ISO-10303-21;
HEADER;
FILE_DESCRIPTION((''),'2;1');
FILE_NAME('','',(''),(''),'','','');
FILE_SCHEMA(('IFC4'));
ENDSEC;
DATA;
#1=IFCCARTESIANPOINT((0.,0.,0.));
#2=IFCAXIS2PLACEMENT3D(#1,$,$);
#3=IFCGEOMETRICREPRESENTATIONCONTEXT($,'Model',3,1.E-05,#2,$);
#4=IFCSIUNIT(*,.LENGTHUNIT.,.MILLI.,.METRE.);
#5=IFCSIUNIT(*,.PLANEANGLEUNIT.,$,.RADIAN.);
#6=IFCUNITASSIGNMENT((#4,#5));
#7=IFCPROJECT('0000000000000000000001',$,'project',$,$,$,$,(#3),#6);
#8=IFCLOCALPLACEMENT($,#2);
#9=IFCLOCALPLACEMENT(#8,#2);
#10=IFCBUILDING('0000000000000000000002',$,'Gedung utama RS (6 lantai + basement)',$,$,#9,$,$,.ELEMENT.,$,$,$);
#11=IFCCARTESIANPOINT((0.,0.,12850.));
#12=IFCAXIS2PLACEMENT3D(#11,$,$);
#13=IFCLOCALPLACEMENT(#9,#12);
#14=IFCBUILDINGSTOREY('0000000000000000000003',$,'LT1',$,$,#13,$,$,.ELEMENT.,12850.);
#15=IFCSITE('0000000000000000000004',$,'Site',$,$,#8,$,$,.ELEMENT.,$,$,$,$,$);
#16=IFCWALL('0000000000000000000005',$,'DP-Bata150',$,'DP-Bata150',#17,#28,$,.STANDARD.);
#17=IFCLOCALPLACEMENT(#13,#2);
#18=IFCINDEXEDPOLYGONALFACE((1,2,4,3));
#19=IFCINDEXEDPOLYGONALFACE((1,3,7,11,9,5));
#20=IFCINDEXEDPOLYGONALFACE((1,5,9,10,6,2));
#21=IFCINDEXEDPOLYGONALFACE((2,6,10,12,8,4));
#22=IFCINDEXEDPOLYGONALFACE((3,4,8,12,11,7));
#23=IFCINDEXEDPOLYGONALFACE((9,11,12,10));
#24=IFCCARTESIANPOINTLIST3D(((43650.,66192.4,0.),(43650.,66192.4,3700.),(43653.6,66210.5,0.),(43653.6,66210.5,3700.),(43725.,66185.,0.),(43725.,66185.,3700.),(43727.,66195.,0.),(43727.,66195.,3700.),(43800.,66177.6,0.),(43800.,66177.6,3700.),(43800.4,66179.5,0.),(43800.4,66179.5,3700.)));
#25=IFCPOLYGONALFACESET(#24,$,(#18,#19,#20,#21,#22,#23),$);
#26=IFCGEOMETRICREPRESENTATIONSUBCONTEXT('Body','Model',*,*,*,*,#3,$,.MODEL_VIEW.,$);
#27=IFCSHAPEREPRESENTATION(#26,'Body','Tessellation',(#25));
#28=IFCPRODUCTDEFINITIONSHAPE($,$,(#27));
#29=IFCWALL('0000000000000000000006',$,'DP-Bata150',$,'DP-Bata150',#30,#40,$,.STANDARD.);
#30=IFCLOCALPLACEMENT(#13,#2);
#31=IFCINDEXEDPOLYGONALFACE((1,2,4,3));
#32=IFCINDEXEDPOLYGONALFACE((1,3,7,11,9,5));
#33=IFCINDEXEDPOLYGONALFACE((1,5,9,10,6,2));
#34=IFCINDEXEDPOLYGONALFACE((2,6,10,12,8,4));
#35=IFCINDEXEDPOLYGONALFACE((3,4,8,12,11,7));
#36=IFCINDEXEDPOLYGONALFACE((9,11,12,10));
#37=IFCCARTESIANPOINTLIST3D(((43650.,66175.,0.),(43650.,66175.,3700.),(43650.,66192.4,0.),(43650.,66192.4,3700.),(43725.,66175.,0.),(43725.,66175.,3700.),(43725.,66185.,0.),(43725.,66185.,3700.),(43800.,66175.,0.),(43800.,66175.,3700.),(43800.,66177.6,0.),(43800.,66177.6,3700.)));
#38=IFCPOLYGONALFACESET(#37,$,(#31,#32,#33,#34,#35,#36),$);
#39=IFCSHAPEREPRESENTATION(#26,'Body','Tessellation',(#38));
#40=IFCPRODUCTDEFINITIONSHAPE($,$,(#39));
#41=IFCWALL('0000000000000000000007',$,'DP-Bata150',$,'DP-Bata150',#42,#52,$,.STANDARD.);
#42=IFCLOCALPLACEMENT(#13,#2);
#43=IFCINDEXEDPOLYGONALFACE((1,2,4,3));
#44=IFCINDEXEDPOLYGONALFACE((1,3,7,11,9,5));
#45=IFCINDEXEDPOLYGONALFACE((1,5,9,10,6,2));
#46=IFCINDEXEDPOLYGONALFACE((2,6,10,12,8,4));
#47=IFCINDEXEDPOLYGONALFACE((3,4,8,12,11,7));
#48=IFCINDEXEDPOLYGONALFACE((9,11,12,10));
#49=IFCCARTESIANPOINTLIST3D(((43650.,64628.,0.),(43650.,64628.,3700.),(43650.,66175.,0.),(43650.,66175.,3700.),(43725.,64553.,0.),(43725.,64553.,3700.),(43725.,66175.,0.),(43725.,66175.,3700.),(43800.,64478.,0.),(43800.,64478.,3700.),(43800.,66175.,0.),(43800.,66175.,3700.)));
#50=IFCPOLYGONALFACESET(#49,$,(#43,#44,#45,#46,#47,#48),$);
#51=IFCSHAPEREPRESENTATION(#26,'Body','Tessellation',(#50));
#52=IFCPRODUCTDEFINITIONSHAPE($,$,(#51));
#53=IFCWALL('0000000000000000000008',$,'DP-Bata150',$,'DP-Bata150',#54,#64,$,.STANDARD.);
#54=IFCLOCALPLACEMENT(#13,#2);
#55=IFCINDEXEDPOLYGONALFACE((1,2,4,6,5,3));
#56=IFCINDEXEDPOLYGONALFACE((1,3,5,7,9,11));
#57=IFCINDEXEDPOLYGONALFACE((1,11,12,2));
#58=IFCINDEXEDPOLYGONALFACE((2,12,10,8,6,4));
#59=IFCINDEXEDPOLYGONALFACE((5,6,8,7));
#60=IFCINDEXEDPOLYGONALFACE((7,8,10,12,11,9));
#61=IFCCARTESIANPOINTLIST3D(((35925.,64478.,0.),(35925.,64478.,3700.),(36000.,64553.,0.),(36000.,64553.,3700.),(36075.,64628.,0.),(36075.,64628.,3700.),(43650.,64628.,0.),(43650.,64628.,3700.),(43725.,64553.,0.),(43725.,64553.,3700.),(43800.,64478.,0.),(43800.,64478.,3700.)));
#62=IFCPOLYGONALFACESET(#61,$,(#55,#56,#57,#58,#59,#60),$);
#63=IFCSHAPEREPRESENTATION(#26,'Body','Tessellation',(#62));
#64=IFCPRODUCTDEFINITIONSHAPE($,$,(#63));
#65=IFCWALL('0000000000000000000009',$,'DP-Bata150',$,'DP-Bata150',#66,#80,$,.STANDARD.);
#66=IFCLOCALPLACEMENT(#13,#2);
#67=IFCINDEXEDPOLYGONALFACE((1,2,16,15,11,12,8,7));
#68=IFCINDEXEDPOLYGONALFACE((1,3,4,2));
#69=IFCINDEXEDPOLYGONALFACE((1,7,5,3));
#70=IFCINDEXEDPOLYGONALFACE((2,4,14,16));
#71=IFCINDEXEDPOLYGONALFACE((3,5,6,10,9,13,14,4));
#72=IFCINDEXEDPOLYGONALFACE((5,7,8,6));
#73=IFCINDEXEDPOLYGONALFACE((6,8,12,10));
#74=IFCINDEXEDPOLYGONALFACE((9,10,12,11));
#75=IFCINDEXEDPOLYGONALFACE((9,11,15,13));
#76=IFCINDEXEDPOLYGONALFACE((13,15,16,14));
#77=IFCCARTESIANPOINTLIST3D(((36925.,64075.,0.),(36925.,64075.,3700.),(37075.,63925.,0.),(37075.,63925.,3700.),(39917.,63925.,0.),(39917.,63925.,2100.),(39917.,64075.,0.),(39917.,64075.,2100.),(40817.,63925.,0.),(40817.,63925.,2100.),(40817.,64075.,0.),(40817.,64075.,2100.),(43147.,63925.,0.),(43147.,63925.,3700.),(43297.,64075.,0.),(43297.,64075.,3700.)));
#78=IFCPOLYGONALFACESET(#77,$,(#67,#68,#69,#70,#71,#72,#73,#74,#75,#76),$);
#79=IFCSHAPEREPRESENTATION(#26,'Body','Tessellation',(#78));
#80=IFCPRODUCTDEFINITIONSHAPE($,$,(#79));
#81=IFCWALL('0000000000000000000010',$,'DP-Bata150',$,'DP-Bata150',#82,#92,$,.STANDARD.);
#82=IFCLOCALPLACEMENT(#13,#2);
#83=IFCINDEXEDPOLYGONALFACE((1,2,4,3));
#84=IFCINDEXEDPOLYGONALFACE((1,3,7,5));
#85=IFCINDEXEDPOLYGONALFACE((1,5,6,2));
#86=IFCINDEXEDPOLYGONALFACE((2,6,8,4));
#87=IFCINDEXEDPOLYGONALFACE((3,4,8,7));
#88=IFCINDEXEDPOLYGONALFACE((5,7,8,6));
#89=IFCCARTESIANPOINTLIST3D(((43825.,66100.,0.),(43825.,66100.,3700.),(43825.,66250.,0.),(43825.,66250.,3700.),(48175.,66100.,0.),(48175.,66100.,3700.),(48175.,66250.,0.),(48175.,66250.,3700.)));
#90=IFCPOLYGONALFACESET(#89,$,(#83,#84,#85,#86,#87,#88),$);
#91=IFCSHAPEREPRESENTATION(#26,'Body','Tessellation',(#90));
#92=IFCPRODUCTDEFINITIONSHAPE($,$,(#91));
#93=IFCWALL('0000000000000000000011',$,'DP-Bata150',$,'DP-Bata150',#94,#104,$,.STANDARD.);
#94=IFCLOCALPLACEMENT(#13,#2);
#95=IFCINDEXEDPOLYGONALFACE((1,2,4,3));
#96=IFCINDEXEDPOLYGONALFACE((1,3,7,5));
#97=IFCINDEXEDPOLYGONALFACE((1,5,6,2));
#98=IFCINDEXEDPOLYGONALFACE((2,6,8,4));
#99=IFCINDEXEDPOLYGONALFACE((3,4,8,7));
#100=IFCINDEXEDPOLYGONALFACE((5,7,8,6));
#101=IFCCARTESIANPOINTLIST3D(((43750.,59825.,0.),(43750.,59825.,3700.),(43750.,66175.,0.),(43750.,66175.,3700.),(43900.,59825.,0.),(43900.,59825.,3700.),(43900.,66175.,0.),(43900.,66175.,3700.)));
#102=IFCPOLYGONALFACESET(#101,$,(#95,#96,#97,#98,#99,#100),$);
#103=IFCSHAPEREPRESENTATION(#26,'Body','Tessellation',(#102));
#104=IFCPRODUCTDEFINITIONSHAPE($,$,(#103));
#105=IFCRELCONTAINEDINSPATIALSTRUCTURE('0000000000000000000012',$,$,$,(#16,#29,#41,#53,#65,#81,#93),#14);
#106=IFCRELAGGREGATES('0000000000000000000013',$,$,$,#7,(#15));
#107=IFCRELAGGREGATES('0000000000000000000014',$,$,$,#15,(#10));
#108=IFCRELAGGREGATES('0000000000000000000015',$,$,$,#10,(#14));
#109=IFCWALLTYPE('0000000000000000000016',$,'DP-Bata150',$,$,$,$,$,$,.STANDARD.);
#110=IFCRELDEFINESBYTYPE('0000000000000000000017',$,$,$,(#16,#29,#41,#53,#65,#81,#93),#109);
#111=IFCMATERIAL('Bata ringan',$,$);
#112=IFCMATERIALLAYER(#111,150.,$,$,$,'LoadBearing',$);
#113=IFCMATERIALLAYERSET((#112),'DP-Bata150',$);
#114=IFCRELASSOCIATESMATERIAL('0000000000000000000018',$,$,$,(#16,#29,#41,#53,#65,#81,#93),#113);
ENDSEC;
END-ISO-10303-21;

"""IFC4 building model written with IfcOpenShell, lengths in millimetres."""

from ifc_helpers import new_model, si_unit, frame, frame_2d, origin, place, context, subcontext, project, spatial, polyline, rectangle, outline, extrude, material, layer, layer_set, layer_usage, type_object, element, save


model = new_model("IFC4")

# Units and contexts
model_context = context("Model", 3, precision=1e-05, world=origin())
body_context = subcontext(model_context, "Body", "Model", "MODEL_VIEW")
ifc_project = project(units=[si_unit("LENGTHUNIT", "METRE", prefix="MILLI"), si_unit("PLANEANGLEUNIT", "RADIAN")], contexts=[model_context])

# Site, building, storey
site_placement = place(None, origin())
site = spatial("IfcSite", under=ifc_project, at=site_placement, Name="Site", CompositionType="ELEMENT")
building_placement = place(site_placement, origin())
building = spatial("IfcBuilding", under=site, at=building_placement, Name="Gedung utama RS (6 lantai + basement)", CompositionType="ELEMENT")
storey_placement = place(building_placement, frame((0.0, 0.0, 12850.0)))
storey = spatial("IfcBuildingStorey", under=building, at=storey_placement, Name="LT1", CompositionType="ELEMENT", Elevation=12850.0)

# Walls
ifc_material_1 = material(Name="Bata ringan")
ifc_layer_1 = layer(ifc_material_1, 150.0, Category="LoadBearing")
ifc_layer_set_1 = layer_set([ifc_layer_1], Name="DP-Bata150")
ifc_layer_usage_1 = layer_usage(ifc_layer_set_1, "AXIS2", "NEGATIVE", 75.0)
wall_type_1 = type_object("IfcWallType", Name="DP-Bata150", PredefinedType="STANDARD")
wall_1_placement = place(storey_placement, frame((43727.0, 66195.0, 0.0), z_axis=(0.0, 0.0, 1.0), x_axis=(-0.196116, -0.980581, 0.0)))
element("IfcWall", 1, at=wall_1_placement, inside=storey, type_object=wall_type_1, material=ifc_layer_usage_1, Name="DP-Bata150", ObjectType="DP-Bata150", PredefinedType="STANDARD", context=body_context, shape_type="SweptSolid", body=[
    extrude(outline(polyline([(-0.8, -75.0), (0.0, 0.0), (0.8, 75.0), (2.8, 75.0), (10.2, 0.0), (17.6, -75.0), (-0.8, -75.0)])), origin(), (0.0, 0.0, 1.0), 3700.0),
])
wall_2_placement = place(storey_placement, frame((43725.0, 66185.0, 0.0), z_axis=(0.0, 0.0, 1.0), x_axis=(0.0, -1.0, 0.0)))
element("IfcWall", 2, at=wall_2_placement, inside=storey, type_object=wall_type_1, material=ifc_layer_usage_1, Name="DP-Bata150", ObjectType="DP-Bata150", PredefinedType="STANDARD", context=body_context, shape_type="SweptSolid", body=[
    extrude(outline(polyline([(-7.4, -75.0), (0.0, 0.0), (7.4, 75.0), (10.0, 75.0), (10.0, 0.0), (10.0, -75.0), (-7.4, -75.0)])), origin(), (0.0, 0.0, 1.0), 3700.0),
])
wall_3_placement = place(storey_placement, frame((43725.0, 66175.0, 0.0), z_axis=(0.0, 0.0, 1.0), x_axis=(0.0, -1.0, 0.0)))
element("IfcWall", 3, at=wall_3_placement, inside=storey, type_object=wall_type_1, material=ifc_layer_usage_1, Name="DP-Bata150", ObjectType="DP-Bata150", PredefinedType="STANDARD", context=body_context, shape_type="SweptSolid", body=[
    extrude(outline(polyline([(0.0, -75.0), (0.0, 0.0), (0.0, 75.0), (1697.0, 75.0), (1622.0, 0.0), (1547.0, -75.0), (0.0, -75.0)])), origin(), (0.0, 0.0, 1.0), 3700.0),
])
wall_4_placement = place(storey_placement, frame((43725.0, 64553.0, 0.0), z_axis=(0.0, 0.0, 1.0), x_axis=(-1.0, 0.0, 0.0)))
element("IfcWall", 4, at=wall_4_placement, inside=storey, type_object=wall_type_1, material=ifc_layer_usage_1, Name="DP-Bata150", ObjectType="DP-Bata150", PredefinedType="STANDARD", context=body_context, shape_type="SweptSolid", body=[
    extrude(outline(polyline([(75.0, -75.0), (0.0, 0.0), (-75.0, 75.0), (7800.0, 75.0), (7725.0, 0.0), (7650.0, -75.0), (75.0, -75.0)])), origin(), (0.0, 0.0, 1.0), 3700.0),
])

# Wall, opening
wall_5_placement = place(storey_placement, frame((43222.0, 64000.0, 0.0), z_axis=(0.0, 0.0, 1.0), x_axis=(-1.0, 0.0, 0.0)))
wall_5 = element("IfcWall", 5, at=wall_5_placement, inside=storey, type_object=wall_type_1, material=ifc_layer_usage_1, Name="DP-Bata150", ObjectType="DP-Bata150", PredefinedType="STANDARD", context=body_context, shape_type="SweptSolid", body=[
    extrude(outline(polyline([(-75.0, -75.0), (0.0, 0.0), (75.0, 75.0), (6147.0, 75.0), (6222.0, 0.0), (6297.0, -75.0), (-75.0, -75.0)])), origin(), (0.0, 0.0, 1.0), 3700.0),
])
opening_placement = place(wall_5_placement, frame((2405.0, 0.0, 0.0), z_axis=(0.0, 0.0, 1.0), x_axis=(1.0, 0.0, 0.0)))
element("IfcOpeningElement", 6, at=opening_placement, cuts=wall_5, PredefinedType="OPENING", context=body_context, shape_type="SweptSolid", body=[
    extrude(rectangle(XDim=900.0, YDim=170.0, at=frame_2d((450.0, 0.0))), origin(), (0.0, 0.0, 1.0), 2100.0),
])

# Walls
wall_6_placement = place(storey_placement, frame((48175.0, 66175.0, 0.0), z_axis=(0.0, 0.0, 1.0), x_axis=(-1.0, 0.0, 0.0)))
element("IfcWall", 7, at=wall_6_placement, inside=storey, type_object=wall_type_1, material=ifc_layer_usage_1, Name="DP-Bata150", ObjectType="DP-Bata150", PredefinedType="STANDARD", context=body_context, shape_type="SweptSolid", body=[
    extrude(outline(polyline([(0.0, -75.0), (0.0, 75.0), (4350.0, 75.0), (4350.0, -75.0), (0.0, -75.0)])), origin(), (0.0, 0.0, 1.0), 3700.0),
])
wall_7_placement = place(storey_placement, frame((43825.0, 66175.0, 0.0), z_axis=(0.0, 0.0, 1.0), x_axis=(0.0, -1.0, 0.0)))
element("IfcWall", 8, at=wall_7_placement, inside=storey, type_object=wall_type_1, material=ifc_layer_usage_1, Name="DP-Bata150", ObjectType="DP-Bata150", PredefinedType="STANDARD", context=body_context, shape_type="SweptSolid", body=[
    extrude(outline(polyline([(0.0, -75.0), (0.0, 75.0), (6350.0, 75.0), (6350.0, -75.0), (0.0, -75.0)])), origin(), (0.0, 0.0, 1.0), 3700.0),
])

save(model, "model.ifc")
